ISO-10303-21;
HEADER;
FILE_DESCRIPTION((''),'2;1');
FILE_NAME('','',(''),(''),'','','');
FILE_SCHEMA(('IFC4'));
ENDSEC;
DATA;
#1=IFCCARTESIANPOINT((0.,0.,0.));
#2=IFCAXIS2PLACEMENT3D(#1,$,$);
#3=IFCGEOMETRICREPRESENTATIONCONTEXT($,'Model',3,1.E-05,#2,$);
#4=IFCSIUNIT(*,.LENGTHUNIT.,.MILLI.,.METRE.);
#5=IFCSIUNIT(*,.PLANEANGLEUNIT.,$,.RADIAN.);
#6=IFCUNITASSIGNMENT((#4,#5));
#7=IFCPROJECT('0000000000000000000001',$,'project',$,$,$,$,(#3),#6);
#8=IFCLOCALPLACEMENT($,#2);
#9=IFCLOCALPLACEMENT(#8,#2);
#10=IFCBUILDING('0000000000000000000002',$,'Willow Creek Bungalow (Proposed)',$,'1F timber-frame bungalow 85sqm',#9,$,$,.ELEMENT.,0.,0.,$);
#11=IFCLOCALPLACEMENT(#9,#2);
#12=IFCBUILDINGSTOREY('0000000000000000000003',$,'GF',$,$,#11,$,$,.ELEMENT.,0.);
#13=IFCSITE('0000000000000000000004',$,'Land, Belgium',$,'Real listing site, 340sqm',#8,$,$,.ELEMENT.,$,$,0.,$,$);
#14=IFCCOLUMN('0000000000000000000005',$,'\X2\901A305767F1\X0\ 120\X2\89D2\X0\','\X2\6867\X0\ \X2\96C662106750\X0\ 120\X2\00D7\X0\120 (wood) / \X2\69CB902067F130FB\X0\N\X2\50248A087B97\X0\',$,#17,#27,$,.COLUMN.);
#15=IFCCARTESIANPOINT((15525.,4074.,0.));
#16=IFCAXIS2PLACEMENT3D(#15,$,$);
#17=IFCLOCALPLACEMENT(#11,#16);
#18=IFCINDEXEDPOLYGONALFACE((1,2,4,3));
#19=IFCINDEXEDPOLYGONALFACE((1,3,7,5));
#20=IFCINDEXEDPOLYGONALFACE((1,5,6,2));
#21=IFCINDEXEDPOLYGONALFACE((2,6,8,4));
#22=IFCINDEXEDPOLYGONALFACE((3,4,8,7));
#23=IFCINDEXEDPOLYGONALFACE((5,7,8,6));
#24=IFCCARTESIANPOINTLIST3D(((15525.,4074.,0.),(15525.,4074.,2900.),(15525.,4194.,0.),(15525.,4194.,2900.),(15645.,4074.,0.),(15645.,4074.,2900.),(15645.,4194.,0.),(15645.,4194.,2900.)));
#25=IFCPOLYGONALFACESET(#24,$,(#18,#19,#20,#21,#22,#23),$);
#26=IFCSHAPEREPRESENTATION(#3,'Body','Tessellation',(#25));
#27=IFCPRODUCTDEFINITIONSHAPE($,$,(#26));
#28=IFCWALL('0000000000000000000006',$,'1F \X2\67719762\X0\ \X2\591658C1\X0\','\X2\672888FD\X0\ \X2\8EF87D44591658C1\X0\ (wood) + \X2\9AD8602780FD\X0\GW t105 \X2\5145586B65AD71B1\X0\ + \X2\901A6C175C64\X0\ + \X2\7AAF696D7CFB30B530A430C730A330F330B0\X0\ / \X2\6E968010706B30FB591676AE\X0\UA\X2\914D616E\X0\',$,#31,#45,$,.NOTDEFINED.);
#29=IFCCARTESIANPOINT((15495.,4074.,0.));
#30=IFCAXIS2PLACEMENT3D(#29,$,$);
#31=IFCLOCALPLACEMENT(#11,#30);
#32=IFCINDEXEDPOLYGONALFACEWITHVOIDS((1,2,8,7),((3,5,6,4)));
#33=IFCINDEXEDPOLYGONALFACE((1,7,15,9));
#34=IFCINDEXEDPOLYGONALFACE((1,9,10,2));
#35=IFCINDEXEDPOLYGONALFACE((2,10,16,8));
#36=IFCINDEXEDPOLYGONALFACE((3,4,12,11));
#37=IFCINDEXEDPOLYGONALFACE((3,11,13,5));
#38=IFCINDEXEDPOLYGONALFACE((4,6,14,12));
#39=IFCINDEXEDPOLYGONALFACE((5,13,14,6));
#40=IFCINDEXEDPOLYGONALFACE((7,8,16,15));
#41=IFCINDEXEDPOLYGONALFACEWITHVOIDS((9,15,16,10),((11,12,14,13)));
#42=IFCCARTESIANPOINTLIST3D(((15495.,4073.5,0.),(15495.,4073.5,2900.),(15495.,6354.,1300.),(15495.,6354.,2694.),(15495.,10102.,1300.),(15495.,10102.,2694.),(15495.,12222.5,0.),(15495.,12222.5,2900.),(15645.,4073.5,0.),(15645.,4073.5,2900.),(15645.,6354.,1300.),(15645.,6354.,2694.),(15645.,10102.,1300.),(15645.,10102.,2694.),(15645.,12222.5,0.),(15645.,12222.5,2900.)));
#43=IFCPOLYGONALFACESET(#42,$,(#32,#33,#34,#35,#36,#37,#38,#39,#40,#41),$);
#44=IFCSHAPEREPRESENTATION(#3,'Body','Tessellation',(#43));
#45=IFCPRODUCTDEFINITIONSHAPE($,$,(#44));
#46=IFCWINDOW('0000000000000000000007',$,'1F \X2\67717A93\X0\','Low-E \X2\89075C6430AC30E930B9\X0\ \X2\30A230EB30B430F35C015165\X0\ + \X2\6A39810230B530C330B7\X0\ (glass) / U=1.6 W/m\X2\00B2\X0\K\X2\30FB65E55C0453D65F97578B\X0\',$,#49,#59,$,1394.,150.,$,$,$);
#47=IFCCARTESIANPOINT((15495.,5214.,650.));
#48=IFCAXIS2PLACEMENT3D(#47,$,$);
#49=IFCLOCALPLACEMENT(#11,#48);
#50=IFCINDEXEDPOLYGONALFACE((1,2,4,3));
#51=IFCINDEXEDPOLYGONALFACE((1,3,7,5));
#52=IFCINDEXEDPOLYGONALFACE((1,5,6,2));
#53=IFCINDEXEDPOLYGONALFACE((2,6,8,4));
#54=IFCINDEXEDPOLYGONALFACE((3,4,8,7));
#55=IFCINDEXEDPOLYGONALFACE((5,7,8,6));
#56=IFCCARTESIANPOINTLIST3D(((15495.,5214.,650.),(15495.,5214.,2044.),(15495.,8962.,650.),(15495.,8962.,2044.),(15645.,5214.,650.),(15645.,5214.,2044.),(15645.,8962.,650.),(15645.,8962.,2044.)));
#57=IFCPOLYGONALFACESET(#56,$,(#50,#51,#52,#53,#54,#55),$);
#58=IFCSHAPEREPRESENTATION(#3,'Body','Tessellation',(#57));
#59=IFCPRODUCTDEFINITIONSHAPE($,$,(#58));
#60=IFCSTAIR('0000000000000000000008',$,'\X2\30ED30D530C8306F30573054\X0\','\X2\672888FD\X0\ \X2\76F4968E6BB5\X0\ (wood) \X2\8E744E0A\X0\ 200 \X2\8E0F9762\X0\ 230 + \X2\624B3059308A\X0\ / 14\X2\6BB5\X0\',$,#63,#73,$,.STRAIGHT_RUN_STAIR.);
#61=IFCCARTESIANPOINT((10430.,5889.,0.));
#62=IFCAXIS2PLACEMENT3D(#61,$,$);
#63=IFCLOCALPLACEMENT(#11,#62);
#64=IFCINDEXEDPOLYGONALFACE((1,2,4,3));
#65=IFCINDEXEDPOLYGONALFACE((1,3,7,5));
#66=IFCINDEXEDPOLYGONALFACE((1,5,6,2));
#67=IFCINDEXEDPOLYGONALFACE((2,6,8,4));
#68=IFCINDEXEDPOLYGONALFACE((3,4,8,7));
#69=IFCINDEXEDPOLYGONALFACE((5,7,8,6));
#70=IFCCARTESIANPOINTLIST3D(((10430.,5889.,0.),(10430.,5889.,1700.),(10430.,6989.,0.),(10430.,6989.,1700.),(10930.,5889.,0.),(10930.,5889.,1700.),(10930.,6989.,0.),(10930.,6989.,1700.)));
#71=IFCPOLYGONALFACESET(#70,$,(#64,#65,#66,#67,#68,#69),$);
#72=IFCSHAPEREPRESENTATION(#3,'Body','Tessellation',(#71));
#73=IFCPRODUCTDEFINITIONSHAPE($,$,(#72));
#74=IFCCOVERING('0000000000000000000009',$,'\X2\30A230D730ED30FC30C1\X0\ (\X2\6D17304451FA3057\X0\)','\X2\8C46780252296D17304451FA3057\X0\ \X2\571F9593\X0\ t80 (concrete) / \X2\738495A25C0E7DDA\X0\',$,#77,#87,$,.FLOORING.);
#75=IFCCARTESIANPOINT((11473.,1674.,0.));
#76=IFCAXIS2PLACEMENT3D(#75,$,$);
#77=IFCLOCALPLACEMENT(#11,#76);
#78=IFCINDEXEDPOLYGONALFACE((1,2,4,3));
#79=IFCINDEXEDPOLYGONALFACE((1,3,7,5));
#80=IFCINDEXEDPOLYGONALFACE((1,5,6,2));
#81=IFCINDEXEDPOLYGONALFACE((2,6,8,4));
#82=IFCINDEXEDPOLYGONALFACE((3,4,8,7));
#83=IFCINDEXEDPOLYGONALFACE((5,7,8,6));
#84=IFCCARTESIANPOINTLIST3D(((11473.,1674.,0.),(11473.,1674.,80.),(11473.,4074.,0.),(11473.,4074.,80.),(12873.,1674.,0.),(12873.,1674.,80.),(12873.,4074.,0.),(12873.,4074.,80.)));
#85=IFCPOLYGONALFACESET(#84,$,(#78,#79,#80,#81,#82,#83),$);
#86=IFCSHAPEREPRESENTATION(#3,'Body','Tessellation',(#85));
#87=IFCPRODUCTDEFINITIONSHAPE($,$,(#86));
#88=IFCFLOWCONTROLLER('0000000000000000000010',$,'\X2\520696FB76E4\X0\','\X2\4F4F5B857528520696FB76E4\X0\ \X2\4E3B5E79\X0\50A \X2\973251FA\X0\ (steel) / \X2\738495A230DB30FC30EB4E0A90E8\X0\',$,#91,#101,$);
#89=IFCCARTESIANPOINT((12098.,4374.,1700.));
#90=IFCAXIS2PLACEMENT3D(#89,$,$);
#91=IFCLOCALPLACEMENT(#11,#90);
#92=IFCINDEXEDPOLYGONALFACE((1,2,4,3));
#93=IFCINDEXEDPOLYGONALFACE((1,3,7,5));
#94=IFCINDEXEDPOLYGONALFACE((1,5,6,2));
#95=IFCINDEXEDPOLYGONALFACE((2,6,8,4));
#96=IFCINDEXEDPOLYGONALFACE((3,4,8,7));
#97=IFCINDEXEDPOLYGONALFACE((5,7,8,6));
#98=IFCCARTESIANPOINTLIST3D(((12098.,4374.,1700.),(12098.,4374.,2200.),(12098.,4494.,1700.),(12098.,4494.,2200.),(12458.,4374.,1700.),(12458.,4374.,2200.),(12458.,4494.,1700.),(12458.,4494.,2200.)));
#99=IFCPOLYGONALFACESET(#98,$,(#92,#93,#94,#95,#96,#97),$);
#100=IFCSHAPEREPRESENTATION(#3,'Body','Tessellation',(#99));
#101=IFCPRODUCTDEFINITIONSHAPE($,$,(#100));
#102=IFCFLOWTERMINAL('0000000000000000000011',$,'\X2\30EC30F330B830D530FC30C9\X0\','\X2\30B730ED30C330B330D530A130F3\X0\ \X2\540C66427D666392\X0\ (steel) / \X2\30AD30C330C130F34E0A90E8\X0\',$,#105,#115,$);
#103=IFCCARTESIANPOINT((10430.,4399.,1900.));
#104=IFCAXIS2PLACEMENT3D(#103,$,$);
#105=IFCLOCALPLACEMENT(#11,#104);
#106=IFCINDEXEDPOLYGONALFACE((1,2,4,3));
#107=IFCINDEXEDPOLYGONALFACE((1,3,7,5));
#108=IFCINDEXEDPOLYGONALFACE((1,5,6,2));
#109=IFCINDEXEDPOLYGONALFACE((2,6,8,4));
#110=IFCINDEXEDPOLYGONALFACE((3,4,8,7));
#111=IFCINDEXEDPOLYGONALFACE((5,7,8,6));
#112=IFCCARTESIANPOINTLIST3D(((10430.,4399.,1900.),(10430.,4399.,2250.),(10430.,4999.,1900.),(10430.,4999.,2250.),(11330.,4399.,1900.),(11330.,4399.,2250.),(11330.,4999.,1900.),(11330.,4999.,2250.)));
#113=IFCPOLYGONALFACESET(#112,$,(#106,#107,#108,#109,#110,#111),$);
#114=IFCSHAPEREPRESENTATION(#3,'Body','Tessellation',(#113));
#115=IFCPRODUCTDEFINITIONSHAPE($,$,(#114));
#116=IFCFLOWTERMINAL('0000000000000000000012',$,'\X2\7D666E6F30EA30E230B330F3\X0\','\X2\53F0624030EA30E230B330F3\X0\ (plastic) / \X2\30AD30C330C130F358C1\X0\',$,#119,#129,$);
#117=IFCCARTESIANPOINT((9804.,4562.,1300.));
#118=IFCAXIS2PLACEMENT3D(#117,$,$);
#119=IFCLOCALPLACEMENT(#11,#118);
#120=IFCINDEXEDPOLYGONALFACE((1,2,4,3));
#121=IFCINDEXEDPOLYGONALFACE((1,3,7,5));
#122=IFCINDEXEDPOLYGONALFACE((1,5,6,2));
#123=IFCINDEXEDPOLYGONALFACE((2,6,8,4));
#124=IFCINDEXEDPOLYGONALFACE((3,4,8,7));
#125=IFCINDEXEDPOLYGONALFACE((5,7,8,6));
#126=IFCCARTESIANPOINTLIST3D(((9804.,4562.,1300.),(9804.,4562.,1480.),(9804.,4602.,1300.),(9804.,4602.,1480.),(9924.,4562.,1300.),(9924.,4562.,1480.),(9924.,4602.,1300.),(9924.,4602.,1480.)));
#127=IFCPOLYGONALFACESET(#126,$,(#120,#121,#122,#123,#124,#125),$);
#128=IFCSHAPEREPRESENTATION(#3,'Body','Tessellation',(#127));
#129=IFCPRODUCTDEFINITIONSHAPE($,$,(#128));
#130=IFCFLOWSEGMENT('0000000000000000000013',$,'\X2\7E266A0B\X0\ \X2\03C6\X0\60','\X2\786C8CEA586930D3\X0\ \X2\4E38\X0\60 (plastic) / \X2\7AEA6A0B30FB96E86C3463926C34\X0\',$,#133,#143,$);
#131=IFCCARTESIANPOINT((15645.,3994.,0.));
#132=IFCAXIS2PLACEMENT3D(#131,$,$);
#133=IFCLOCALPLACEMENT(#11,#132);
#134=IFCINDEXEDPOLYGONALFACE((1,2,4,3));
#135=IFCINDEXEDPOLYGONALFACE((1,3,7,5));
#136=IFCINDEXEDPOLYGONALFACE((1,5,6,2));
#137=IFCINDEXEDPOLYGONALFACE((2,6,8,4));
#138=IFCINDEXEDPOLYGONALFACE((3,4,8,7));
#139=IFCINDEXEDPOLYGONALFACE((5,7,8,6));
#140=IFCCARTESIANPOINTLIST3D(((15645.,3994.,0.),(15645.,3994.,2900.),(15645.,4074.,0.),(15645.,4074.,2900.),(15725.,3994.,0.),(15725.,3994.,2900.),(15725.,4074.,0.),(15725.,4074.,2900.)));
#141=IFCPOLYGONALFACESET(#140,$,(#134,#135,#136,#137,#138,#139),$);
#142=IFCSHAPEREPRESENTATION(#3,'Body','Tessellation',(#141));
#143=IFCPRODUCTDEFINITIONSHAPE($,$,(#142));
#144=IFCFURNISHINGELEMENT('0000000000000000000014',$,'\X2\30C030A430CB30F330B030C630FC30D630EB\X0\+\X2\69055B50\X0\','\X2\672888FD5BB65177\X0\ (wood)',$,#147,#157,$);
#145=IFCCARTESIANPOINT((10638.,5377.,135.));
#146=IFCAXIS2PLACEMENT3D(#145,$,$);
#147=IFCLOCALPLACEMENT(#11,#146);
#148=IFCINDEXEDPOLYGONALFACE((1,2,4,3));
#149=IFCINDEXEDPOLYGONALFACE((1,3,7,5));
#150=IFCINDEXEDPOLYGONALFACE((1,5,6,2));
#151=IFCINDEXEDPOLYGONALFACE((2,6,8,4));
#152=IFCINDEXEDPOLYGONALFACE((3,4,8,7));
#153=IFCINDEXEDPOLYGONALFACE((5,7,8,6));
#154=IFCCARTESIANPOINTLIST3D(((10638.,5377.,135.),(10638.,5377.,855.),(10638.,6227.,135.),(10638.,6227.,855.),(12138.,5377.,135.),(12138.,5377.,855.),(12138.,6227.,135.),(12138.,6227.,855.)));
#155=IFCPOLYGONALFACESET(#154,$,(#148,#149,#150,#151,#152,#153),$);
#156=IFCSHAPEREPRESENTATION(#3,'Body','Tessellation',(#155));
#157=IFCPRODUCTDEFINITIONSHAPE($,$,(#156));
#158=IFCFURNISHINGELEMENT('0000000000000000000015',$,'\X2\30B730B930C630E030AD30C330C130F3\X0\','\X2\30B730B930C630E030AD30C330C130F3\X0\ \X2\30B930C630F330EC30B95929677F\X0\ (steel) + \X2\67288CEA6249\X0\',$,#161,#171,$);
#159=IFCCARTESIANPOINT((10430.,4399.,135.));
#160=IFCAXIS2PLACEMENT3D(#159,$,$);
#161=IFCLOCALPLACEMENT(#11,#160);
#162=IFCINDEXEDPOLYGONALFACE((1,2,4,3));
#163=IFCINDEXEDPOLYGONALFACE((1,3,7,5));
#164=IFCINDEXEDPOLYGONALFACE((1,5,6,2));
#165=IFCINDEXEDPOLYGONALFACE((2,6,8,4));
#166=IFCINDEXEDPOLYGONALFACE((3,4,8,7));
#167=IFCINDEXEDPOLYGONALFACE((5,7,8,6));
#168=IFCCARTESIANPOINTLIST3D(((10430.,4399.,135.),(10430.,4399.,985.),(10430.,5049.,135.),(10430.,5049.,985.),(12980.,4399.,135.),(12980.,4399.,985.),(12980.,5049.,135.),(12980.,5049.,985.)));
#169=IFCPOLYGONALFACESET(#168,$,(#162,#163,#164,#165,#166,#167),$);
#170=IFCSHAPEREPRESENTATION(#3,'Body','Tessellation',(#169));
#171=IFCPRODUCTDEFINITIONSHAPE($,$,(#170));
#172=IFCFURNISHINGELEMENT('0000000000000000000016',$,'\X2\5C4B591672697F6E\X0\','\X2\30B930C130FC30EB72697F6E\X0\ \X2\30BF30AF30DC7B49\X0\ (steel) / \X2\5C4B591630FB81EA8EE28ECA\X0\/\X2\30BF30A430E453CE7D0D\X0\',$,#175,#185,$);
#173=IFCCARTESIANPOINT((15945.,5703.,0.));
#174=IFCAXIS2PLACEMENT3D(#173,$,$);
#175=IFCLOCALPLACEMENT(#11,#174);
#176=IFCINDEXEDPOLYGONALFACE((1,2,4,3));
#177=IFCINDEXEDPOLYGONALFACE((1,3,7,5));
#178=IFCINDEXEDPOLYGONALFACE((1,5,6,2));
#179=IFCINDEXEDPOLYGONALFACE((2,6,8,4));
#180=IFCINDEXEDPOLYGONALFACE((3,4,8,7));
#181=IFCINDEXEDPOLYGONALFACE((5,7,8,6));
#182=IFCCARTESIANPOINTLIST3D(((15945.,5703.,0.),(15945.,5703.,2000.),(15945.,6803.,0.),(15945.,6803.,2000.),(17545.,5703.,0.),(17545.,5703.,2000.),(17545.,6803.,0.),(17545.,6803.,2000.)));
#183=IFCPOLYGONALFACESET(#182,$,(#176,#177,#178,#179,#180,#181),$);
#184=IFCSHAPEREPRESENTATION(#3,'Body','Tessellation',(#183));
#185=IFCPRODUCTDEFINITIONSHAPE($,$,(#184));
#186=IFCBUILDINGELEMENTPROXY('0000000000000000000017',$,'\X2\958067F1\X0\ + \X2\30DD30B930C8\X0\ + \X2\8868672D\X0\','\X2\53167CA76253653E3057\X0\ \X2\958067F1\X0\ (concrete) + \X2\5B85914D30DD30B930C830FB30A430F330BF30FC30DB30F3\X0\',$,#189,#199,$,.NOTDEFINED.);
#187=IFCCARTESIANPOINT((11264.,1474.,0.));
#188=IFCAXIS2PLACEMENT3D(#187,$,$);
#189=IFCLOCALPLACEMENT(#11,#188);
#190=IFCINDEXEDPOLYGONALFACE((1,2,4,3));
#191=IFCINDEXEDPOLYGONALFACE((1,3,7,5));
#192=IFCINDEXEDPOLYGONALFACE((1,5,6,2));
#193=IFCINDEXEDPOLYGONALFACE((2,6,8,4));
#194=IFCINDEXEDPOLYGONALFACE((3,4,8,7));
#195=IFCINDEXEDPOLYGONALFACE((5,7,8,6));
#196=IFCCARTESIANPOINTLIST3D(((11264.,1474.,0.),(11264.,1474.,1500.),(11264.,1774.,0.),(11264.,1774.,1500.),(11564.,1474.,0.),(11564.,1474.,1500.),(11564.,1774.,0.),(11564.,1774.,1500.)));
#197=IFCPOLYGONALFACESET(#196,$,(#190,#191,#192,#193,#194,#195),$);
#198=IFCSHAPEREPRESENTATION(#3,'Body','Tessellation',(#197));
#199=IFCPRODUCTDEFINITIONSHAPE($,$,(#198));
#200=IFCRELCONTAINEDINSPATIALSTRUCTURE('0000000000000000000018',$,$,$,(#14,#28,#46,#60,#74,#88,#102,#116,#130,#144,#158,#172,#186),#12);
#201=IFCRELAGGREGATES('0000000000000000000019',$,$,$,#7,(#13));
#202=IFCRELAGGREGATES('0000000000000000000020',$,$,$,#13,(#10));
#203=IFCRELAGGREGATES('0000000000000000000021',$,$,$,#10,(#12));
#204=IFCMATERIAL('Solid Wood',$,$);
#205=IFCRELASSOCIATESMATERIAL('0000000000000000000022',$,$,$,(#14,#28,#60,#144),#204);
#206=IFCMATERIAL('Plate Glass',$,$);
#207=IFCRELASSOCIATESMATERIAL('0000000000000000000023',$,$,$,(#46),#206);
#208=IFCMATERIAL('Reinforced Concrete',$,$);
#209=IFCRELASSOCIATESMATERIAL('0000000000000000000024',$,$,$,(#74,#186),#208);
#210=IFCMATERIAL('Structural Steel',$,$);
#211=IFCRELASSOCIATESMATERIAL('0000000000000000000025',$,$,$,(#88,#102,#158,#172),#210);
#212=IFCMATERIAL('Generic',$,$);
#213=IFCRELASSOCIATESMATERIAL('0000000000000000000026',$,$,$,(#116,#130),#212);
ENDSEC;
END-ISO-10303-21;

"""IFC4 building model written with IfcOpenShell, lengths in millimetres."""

from ifc_helpers import new_model, si_unit, frame, frame_2d, origin, place, context, project, spatial, rectangle, extrude, material, element, fill, save


model = new_model("IFC4")

# Units and contexts
model_context = context("Model", 3, precision=1e-05, world=origin())
ifc_project = project(units=[si_unit("LENGTHUNIT", "METRE", prefix="MILLI"), si_unit("PLANEANGLEUNIT", "RADIAN")], contexts=[model_context])

# Site, building, storey
site_placement = place(None, origin())
site = spatial("IfcSite", under=ifc_project, at=site_placement, Name="Land, Belgium", ObjectType="Real listing site, 340sqm", CompositionType="ELEMENT", RefElevation=0.0)
building_placement = place(site_placement, origin())
building = spatial("IfcBuilding", under=site, at=building_placement, Name="Willow Creek Bungalow (Proposed)", ObjectType="1F timber-frame bungalow 85sqm", CompositionType="ELEMENT", ElevationOfRefHeight=0.0, ElevationOfTerrain=0.0)
storey_placement = place(building_placement, origin())
storey = spatial("IfcBuildingStorey", under=building, at=storey_placement, Name="GF", CompositionType="ELEMENT", Elevation=0.0)

# Column
ifc_material_1 = material(Name="Solid Wood")
column_1_placement = place(storey_placement, frame((15525.0, 4074.0, 0.0)))
element("IfcColumn", 1, at=column_1_placement, inside=storey, material=ifc_material_1, Name="通し柱 120角", Description="桧 集成材 120×120 (wood) / 構造柱・N値計算", PredefinedType="COLUMN", context=model_context, shape_type="SweptSolid", body=[
    extrude(rectangle(XDim=120.0, YDim=120.0, at=frame_2d((60.0, 60.0))), frame((15525.0, 4074.0, 0.0)), (0.0, 0.0, 1.0), 2900.0),
])

# Wall, opening, window
wall_1_placement = place(storey_placement, frame((15495.0, 4074.0, 0.0)))
wall_1 = element("IfcWall", 2, at=wall_1_placement, inside=storey, material=ifc_material_1, Name="1F 東面 外壁", Description="木製 軸組外壁 (wood) + 高性能GW t105 充填断熱 + 通気層 + 窯業系サイディング / 準耐火・外皮UA配慮", PredefinedType="NOTDEFINED", context=model_context, shape_type="SweptSolid", body=[
    extrude(rectangle(XDim=150.0, YDim=8149.0, at=frame_2d((75.0, 4074.0))), frame((15495.0, 4074.0, 0.0)), (0.0, 0.0, 1.0), 2900.0),
])
opening_placement = place(storey_placement, frame((15495.0, 5214.0, 650.0)))
opening = element("IfcOpeningElement", 3, at=opening_placement, cuts=wall_1, PredefinedType="NOTDEFINED", context=model_context, shape_type="SweptSolid", body=[
    extrude(rectangle(XDim=150.0, YDim=3748.0, at=frame_2d((75.0, 1874.0))), frame((15495.0, 5214.0, 650.0)), (0.0, 0.0, 1.0), 1394.0),
])
ifc_material_2 = material(Name="Plate Glass")
window_placement = place(storey_placement, frame((15495.0, 5214.0, 650.0)))
window = element("IfcWindow", 4, at=window_placement, inside=storey, material=ifc_material_2, Name="1F 東窓", Description="Low-E 複層ガラス アルゴン封入 + 樹脂サッシ (glass) / U=1.6 W/m²K・日射取得型", OverallHeight=1394.0, OverallWidth=150.0, context=model_context, shape_type="SweptSolid", body=[
    extrude(rectangle(XDim=150.0, YDim=3748.0, at=frame_2d((75.0, 1874.0))), frame((15495.0, 5214.0, 650.0)), (0.0, 0.0, 1.0), 1394.0),
])
fill(opening, window)

# Stair
stair_placement = place(storey_placement, frame((10430.0, 5889.0, 0.0)))
element("IfcStair", 5, at=stair_placement, inside=storey, material=ifc_material_1, Name="ロフトはしご", Description="木製 直階段 (wood) 蹴上 200 踏面 230 + 手すり / 14段", PredefinedType="STRAIGHT_RUN_STAIR", context=model_context, shape_type="SweptSolid", body=[
    extrude(rectangle(XDim=500.0, YDim=1100.0, at=frame_2d((250.0, 550.0))), frame((10430.0, 5889.0, 0.0)), (0.0, 0.0, 1.0), 1700.0),
])

# Covering
ifc_material_3 = material(Name="Reinforced Concrete")
covering_placement = place(storey_placement, frame((11473.0, 1674.0, 0.0)))
element("IfcCovering", 6, at=covering_placement, inside=storey, material=ifc_material_3, Name="アプローチ (洗い出し)", Description="豆砂利洗い出し 土間 t80 (concrete) / 玄関導線", PredefinedType="FLOORING", context=model_context, shape_type="SweptSolid", body=[
    extrude(rectangle(XDim=1400.0, YDim=2400.0, at=frame_2d((700.0, 1200.0))), frame((11473.0, 1674.0, 0.0)), (0.0, 0.0, 1.0), 80.0),
])

# Flow controller
ifc_material_4 = material(Name="Structural Steel")
flow_controller_placement = place(storey_placement, frame((12098.0, 4374.0, 1700.0)))
element("IfcFlowController", 7, at=flow_controller_placement, inside=storey, material=ifc_material_4, Name="分電盤", Description="住宅用分電盤 主幹50A 露出 (steel) / 玄関ホール上部", context=model_context, shape_type="SweptSolid", body=[
    extrude(rectangle(XDim=360.0, YDim=120.0, at=frame_2d((180.0, 60.0))), frame((12098.0, 4374.0, 1700.0)), (0.0, 0.0, 1.0), 500.0),
])

# Flow terminals
flow_terminal_1_placement = place(storey_placement, frame((10430.0, 4399.0, 1900.0)))
element("IfcFlowTerminal", 8, at=flow_terminal_1_placement, inside=storey, material=ifc_material_4, Name="レンジフード", Description="シロッコファン 同時給排 (steel) / キッチン上部", context=model_context, shape_type="SweptSolid", body=[
    extrude(rectangle(XDim=900.0, YDim=600.0, at=frame_2d((450.0, 300.0))), frame((10430.0, 4399.0, 1900.0)), (0.0, 0.0, 1.0), 350.0),
])
ifc_material_5 = material(Name="Generic")
flow_terminal_2_placement = place(storey_placement, frame((9804.0, 4562.0, 1300.0)))
element("IfcFlowTerminal", 9, at=flow_terminal_2_placement, inside=storey, material=ifc_material_5, Name="給湯リモコン", Description="台所リモコン (plastic) / キッチン壁", context=model_context, shape_type="SweptSolid", body=[
    extrude(rectangle(XDim=120.0, YDim=40.0, at=frame_2d((60.0, 20.0))), frame((9804.0, 4562.0, 1300.0)), (0.0, 0.0, 1.0), 180.0),
])

# Flow segment
flow_segment_placement = place(storey_placement, frame((15645.0, 3994.0, 0.0)))
element("IfcFlowSegment", 10, at=flow_segment_placement, inside=storey, material=ifc_material_5, Name="縦樋 φ60", Description="硬質塩ビ 丸60 (plastic) / 竪樋・雨水排水", context=model_context, shape_type="SweptSolid", body=[
    extrude(rectangle(XDim=80.0, YDim=80.0, at=frame_2d((40.0, 40.0))), frame((15645.0, 3994.0, 0.0)), (0.0, 0.0, 1.0), 2900.0),
])

# Furnishing elements
furnishing_1_placement = place(storey_placement, frame((10638.0, 5377.0, 135.0)))
element("IfcFurnishingElement", 11, at=furnishing_1_placement, inside=storey, material=ifc_material_1, Name="ダイニングテーブル+椅子", Description="木製家具 (wood)", context=model_context, shape_type="SweptSolid", body=[
    extrude(rectangle(XDim=1500.0, YDim=850.0, at=frame_2d((750.0, 425.0))), frame((10638.0, 5377.0, 135.0)), (0.0, 0.0, 1.0), 720.0),
])
furnishing_2_placement = place(storey_placement, frame((10430.0, 4399.0, 135.0)))
element("IfcFurnishingElement", 12, at=furnishing_2_placement, inside=storey, material=ifc_material_4, Name="システムキッチン", Description="システムキッチン ステンレス天板 (steel) + 木質扉", context=model_context, shape_type="SweptSolid", body=[
    extrude(rectangle(XDim=2550.0, YDim=650.0, at=frame_2d((1275.0, 325.0))), frame((10430.0, 4399.0, 135.0)), (0.0, 0.0, 1.0), 850.0),
])
furnishing_3_placement = place(storey_placement, frame((15945.0, 5703.0, 0.0)))
element("IfcFurnishingElement", 13, at=furnishing_3_placement, inside=storey, material=ifc_material_4, Name="屋外物置", Description="スチール物置 タクボ等 (steel) / 屋外・自転車/タイヤ収納", context=model_context, shape_type="SweptSolid", body=[
    extrude(rectangle(XDim=1600.0, YDim=1100.0, at=frame_2d((800.0, 550.0))), frame((15945.0, 5703.0, 0.0)), (0.0, 0.0, 1.0), 2000.0),
])

# Building element proxy
proxy_placement = place(storey_placement, frame((11264.0, 1474.0, 0.0)))
element("IfcBuildingElementProxy", 14, at=proxy_placement, inside=storey, material=ifc_material_3, Name="門柱 + ポスト + 表札", Description="化粧打放し 門柱 (concrete) + 宅配ポスト・インターホン", PredefinedType="NOTDEFINED", context=model_context, shape_type="SweptSolid", body=[
    extrude(rectangle(XDim=300.0, YDim=300.0, at=frame_2d((150.0, 150.0))), frame((11264.0, 1474.0, 0.0)), (0.0, 0.0, 1.0), 1500.0),
])

save(model, "model.ifc")
